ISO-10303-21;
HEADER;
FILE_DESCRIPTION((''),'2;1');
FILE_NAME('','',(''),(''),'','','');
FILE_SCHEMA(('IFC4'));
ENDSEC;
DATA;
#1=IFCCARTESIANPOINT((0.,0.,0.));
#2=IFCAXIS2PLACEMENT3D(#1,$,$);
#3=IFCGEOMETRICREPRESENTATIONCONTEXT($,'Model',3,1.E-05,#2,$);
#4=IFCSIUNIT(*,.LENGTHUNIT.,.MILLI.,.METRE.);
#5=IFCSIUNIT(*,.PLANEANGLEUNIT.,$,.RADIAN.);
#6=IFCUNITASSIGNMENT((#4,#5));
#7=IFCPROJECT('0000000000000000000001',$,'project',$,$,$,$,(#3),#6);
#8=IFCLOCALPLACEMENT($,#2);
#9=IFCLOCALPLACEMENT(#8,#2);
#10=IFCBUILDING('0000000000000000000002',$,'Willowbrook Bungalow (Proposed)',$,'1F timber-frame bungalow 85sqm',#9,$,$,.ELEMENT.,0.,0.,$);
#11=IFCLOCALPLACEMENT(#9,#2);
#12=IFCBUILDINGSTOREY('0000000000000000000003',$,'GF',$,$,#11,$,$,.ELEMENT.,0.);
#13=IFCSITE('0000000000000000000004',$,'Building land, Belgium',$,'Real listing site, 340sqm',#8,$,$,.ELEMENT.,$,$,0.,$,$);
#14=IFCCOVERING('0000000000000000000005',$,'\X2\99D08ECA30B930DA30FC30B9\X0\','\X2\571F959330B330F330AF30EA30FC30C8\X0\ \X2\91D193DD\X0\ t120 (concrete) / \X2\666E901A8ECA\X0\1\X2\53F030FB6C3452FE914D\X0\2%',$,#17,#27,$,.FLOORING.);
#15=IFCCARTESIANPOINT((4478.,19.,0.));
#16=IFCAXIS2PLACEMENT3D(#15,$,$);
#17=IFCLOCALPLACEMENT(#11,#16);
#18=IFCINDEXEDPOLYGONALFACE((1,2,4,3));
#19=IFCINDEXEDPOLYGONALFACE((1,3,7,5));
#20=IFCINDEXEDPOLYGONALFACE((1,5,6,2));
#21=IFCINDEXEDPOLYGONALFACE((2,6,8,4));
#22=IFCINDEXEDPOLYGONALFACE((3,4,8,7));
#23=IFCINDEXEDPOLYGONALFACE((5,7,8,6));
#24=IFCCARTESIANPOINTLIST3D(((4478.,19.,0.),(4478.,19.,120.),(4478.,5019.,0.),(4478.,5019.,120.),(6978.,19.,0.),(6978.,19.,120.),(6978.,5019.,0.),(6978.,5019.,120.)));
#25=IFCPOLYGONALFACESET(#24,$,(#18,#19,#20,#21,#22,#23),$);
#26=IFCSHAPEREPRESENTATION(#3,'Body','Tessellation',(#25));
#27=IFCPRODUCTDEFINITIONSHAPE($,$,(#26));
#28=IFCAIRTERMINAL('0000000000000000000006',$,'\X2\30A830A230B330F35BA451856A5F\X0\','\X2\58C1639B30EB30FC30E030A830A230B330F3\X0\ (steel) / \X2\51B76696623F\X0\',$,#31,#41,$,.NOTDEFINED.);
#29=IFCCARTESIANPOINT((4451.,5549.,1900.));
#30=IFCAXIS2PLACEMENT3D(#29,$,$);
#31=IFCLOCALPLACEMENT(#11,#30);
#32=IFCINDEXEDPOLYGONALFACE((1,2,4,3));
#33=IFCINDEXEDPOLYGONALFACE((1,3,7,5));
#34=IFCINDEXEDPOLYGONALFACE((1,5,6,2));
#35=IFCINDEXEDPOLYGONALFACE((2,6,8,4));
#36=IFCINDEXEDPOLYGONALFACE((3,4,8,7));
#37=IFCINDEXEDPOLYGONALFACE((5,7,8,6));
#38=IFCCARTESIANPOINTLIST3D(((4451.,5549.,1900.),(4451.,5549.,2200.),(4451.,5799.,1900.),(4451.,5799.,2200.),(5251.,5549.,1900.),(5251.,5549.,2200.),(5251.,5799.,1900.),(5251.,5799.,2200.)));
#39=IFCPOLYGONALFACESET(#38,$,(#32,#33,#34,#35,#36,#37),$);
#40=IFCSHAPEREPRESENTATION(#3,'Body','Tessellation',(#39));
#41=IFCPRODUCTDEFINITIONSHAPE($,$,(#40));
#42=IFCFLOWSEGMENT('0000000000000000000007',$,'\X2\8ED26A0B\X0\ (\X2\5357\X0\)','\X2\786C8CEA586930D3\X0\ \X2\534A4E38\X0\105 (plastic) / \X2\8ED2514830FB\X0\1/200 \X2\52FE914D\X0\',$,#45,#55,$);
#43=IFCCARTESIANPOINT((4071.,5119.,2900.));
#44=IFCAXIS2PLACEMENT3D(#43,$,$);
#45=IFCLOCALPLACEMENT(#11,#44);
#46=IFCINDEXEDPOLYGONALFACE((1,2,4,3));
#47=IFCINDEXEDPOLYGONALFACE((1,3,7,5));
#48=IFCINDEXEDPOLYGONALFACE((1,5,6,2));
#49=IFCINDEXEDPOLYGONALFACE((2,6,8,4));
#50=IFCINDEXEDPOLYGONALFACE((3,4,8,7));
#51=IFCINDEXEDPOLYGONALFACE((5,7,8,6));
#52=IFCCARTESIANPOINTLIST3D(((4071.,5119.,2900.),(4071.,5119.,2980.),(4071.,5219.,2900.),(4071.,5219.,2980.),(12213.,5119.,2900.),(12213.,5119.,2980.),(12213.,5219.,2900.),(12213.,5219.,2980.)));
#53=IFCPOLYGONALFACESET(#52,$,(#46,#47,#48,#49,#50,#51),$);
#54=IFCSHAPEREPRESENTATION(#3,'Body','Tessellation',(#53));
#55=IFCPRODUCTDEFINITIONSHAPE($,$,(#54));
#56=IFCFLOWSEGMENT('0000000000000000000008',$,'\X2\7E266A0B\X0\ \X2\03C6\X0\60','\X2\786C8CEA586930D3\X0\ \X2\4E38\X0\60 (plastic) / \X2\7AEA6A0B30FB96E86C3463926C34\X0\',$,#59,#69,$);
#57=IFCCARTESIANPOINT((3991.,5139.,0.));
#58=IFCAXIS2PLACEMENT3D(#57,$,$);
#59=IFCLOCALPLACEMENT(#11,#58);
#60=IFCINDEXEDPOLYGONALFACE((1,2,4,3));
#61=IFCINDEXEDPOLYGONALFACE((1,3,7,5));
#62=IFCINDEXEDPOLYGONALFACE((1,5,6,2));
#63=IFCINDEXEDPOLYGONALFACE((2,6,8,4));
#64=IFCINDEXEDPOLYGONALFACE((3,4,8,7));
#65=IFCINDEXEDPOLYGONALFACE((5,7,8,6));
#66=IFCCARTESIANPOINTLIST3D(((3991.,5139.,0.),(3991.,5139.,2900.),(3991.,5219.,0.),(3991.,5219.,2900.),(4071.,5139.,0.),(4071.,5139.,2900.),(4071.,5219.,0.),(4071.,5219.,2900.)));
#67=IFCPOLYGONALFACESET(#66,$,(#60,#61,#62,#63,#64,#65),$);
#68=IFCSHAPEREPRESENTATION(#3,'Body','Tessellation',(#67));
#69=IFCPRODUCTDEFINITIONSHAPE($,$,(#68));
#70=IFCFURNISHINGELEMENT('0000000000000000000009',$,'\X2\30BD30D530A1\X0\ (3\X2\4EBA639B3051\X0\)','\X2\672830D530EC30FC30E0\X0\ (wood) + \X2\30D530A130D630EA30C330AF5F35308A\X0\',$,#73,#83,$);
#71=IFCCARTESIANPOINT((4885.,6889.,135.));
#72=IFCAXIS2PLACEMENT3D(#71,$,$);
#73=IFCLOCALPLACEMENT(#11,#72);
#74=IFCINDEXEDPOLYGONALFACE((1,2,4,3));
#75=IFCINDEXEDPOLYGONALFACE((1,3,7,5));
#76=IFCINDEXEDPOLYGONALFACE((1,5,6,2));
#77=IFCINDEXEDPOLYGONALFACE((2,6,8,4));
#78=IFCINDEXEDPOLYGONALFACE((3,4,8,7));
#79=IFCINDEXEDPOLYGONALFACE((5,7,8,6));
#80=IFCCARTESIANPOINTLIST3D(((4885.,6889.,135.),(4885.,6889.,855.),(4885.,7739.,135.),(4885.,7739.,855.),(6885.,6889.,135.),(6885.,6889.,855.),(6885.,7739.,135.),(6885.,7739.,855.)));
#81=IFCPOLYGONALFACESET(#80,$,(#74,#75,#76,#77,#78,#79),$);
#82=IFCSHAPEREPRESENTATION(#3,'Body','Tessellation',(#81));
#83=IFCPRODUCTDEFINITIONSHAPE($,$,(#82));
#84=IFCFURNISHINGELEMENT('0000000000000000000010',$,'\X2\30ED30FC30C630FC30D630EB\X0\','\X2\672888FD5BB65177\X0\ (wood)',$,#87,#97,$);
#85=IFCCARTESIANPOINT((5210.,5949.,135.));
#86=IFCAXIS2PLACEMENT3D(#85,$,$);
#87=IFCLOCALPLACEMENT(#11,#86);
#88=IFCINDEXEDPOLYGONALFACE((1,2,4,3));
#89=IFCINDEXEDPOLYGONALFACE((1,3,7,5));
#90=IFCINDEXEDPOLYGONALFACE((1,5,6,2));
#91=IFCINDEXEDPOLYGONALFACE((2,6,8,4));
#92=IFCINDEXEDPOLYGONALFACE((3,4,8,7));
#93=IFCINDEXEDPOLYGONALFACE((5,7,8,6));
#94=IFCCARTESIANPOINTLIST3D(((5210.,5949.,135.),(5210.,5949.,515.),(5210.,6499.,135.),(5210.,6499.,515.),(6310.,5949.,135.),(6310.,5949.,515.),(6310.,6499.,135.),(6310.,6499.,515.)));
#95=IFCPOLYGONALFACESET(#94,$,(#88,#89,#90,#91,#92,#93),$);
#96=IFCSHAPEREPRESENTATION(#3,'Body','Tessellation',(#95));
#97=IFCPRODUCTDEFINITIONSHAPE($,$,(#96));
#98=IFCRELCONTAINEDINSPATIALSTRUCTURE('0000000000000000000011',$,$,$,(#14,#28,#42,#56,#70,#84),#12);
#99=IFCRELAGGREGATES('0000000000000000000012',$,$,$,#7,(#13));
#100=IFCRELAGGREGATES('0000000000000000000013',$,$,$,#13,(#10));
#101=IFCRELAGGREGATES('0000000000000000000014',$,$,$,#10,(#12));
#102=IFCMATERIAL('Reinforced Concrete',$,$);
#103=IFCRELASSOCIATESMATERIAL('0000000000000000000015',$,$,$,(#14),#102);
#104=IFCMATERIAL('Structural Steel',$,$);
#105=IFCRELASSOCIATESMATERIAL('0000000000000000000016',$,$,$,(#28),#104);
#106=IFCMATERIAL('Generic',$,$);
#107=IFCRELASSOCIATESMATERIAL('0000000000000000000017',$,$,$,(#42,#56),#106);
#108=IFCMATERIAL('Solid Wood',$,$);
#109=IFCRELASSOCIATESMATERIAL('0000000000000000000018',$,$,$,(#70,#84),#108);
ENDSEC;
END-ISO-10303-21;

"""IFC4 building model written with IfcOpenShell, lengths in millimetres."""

from ifc_helpers import new_model, si_unit, frame, frame_2d, origin, place, context, project, spatial, rectangle, extrude, material, element, save


model = new_model("IFC4")

# Units and contexts
model_context = context("Model", 3, precision=1e-05, world=origin())
ifc_project = project(units=[si_unit("LENGTHUNIT", "METRE", prefix="MILLI"), si_unit("PLANEANGLEUNIT", "RADIAN")], contexts=[model_context])

# Site, building, storey
site_placement = place(None, origin())
site = spatial("IfcSite", under=ifc_project, at=site_placement, Name="Building land, Belgium", ObjectType="Real listing site, 340sqm", CompositionType="ELEMENT", RefElevation=0.0)
building_placement = place(site_placement, origin())
building = spatial("IfcBuilding", under=site, at=building_placement, Name="Willowbrook Bungalow (Proposed)", ObjectType="1F timber-frame bungalow 85sqm", CompositionType="ELEMENT", ElevationOfRefHeight=0.0, ElevationOfTerrain=0.0)
storey_placement = place(building_placement, origin())
storey = spatial("IfcBuildingStorey", under=building, at=storey_placement, Name="GF", CompositionType="ELEMENT", Elevation=0.0)

# Shared definitions
ifc_material_1 = material(Name="Solid Wood")

# Shared definitions
ifc_material_2 = material(Name="Reinforced Concrete")

# Shared definitions
ifc_material_3 = material(Name="Structural Steel")

# Covering
ifc_material_4 = material(Name="Generic")
covering_1_placement = place(storey_placement, frame((4478.0, 19.0, 0.0)))
element("IfcCovering", 1, at=covering_1_placement, inside=storey, material=ifc_material_2, Name="駐車スペース", Description="土間コンクリート 金鏝 t120 (concrete) / 普通車1台・水勾配2%", PredefinedType="FLOORING", context=model_context, shape_type="SweptSolid", body=[
    extrude(rectangle(XDim=2500.0, YDim=5000.0, at=frame_2d((1250.0, 2500.0))), frame((4478.0, 19.0, 0.0)), (0.0, 0.0, 1.0), 120.0),
])

# Air terminal
air_terminal_placement = place(storey_placement, frame((4451.0, 5549.0, 1900.0)))
element("IfcAirTerminal", 2, at=air_terminal_placement, inside=storey, material=ifc_material_3, Name="エアコン室内機", Description="壁掛ルームエアコン (steel) / 冷暖房", PredefinedType="NOTDEFINED", context=model_context, shape_type="SweptSolid", body=[
    extrude(rectangle(XDim=800.0, YDim=250.0, at=frame_2d((400.0, 125.0))), frame((4451.0, 5549.0, 1900.0)), (0.0, 0.0, 1.0), 300.0),
])

# Flow segments
flow_segment_1_placement = place(storey_placement, frame((4071.0, 5119.0, 2900.0)))
element("IfcFlowSegment", 3, at=flow_segment_1_placement, inside=storey, material=ifc_material_4, Name="軒樋 (南)", Description="硬質塩ビ 半丸105 (plastic) / 軒先・1/200 勾配", context=model_context, shape_type="SweptSolid", body=[
    extrude(rectangle(XDim=8142.0, YDim=100.0, at=frame_2d((4071.0, 50.0))), frame((4071.0, 5119.0, 2900.0)), (0.0, 0.0, 1.0), 80.0),
])
flow_segment_2_placement = place(storey_placement, frame((3991.0, 5139.0, 0.0)))
element("IfcFlowSegment", 4, at=flow_segment_2_placement, inside=storey, material=ifc_material_4, Name="縦樋 φ60", Description="硬質塩ビ 丸60 (plastic) / 竪樋・雨水排水", context=model_context, shape_type="SweptSolid", body=[
    extrude(rectangle(XDim=80.0, YDim=80.0, at=frame_2d((40.0, 40.0))), frame((3991.0, 5139.0, 0.0)), (0.0, 0.0, 1.0), 2900.0),
])

# Furnishing elements
furnishing_1_placement = place(storey_placement, frame((4885.0, 6889.0, 135.0)))
element("IfcFurnishingElement", 5, at=furnishing_1_placement, inside=storey, material=ifc_material_1, Name="ソファ (3人掛け)", Description="木フレーム (wood) + ファブリック張り", context=model_context, shape_type="SweptSolid", body=[
    extrude(rectangle(XDim=2000.0, YDim=850.0, at=frame_2d((1000.0, 425.0))), frame((4885.0, 6889.0, 135.0)), (0.0, 0.0, 1.0), 720.0),
])
furnishing_2_placement = place(storey_placement, frame((5210.0, 5949.0, 135.0)))
element("IfcFurnishingElement", 6, at=furnishing_2_placement, inside=storey, material=ifc_material_1, Name="ローテーブル", Description="木製家具 (wood)", context=model_context, shape_type="SweptSolid", body=[
    extrude(rectangle(XDim=1100.0, YDim=550.0, at=frame_2d((550.0, 275.0))), frame((5210.0, 5949.0, 135.0)), (0.0, 0.0, 1.0), 380.0),
])

save(model, "model.ifc")
